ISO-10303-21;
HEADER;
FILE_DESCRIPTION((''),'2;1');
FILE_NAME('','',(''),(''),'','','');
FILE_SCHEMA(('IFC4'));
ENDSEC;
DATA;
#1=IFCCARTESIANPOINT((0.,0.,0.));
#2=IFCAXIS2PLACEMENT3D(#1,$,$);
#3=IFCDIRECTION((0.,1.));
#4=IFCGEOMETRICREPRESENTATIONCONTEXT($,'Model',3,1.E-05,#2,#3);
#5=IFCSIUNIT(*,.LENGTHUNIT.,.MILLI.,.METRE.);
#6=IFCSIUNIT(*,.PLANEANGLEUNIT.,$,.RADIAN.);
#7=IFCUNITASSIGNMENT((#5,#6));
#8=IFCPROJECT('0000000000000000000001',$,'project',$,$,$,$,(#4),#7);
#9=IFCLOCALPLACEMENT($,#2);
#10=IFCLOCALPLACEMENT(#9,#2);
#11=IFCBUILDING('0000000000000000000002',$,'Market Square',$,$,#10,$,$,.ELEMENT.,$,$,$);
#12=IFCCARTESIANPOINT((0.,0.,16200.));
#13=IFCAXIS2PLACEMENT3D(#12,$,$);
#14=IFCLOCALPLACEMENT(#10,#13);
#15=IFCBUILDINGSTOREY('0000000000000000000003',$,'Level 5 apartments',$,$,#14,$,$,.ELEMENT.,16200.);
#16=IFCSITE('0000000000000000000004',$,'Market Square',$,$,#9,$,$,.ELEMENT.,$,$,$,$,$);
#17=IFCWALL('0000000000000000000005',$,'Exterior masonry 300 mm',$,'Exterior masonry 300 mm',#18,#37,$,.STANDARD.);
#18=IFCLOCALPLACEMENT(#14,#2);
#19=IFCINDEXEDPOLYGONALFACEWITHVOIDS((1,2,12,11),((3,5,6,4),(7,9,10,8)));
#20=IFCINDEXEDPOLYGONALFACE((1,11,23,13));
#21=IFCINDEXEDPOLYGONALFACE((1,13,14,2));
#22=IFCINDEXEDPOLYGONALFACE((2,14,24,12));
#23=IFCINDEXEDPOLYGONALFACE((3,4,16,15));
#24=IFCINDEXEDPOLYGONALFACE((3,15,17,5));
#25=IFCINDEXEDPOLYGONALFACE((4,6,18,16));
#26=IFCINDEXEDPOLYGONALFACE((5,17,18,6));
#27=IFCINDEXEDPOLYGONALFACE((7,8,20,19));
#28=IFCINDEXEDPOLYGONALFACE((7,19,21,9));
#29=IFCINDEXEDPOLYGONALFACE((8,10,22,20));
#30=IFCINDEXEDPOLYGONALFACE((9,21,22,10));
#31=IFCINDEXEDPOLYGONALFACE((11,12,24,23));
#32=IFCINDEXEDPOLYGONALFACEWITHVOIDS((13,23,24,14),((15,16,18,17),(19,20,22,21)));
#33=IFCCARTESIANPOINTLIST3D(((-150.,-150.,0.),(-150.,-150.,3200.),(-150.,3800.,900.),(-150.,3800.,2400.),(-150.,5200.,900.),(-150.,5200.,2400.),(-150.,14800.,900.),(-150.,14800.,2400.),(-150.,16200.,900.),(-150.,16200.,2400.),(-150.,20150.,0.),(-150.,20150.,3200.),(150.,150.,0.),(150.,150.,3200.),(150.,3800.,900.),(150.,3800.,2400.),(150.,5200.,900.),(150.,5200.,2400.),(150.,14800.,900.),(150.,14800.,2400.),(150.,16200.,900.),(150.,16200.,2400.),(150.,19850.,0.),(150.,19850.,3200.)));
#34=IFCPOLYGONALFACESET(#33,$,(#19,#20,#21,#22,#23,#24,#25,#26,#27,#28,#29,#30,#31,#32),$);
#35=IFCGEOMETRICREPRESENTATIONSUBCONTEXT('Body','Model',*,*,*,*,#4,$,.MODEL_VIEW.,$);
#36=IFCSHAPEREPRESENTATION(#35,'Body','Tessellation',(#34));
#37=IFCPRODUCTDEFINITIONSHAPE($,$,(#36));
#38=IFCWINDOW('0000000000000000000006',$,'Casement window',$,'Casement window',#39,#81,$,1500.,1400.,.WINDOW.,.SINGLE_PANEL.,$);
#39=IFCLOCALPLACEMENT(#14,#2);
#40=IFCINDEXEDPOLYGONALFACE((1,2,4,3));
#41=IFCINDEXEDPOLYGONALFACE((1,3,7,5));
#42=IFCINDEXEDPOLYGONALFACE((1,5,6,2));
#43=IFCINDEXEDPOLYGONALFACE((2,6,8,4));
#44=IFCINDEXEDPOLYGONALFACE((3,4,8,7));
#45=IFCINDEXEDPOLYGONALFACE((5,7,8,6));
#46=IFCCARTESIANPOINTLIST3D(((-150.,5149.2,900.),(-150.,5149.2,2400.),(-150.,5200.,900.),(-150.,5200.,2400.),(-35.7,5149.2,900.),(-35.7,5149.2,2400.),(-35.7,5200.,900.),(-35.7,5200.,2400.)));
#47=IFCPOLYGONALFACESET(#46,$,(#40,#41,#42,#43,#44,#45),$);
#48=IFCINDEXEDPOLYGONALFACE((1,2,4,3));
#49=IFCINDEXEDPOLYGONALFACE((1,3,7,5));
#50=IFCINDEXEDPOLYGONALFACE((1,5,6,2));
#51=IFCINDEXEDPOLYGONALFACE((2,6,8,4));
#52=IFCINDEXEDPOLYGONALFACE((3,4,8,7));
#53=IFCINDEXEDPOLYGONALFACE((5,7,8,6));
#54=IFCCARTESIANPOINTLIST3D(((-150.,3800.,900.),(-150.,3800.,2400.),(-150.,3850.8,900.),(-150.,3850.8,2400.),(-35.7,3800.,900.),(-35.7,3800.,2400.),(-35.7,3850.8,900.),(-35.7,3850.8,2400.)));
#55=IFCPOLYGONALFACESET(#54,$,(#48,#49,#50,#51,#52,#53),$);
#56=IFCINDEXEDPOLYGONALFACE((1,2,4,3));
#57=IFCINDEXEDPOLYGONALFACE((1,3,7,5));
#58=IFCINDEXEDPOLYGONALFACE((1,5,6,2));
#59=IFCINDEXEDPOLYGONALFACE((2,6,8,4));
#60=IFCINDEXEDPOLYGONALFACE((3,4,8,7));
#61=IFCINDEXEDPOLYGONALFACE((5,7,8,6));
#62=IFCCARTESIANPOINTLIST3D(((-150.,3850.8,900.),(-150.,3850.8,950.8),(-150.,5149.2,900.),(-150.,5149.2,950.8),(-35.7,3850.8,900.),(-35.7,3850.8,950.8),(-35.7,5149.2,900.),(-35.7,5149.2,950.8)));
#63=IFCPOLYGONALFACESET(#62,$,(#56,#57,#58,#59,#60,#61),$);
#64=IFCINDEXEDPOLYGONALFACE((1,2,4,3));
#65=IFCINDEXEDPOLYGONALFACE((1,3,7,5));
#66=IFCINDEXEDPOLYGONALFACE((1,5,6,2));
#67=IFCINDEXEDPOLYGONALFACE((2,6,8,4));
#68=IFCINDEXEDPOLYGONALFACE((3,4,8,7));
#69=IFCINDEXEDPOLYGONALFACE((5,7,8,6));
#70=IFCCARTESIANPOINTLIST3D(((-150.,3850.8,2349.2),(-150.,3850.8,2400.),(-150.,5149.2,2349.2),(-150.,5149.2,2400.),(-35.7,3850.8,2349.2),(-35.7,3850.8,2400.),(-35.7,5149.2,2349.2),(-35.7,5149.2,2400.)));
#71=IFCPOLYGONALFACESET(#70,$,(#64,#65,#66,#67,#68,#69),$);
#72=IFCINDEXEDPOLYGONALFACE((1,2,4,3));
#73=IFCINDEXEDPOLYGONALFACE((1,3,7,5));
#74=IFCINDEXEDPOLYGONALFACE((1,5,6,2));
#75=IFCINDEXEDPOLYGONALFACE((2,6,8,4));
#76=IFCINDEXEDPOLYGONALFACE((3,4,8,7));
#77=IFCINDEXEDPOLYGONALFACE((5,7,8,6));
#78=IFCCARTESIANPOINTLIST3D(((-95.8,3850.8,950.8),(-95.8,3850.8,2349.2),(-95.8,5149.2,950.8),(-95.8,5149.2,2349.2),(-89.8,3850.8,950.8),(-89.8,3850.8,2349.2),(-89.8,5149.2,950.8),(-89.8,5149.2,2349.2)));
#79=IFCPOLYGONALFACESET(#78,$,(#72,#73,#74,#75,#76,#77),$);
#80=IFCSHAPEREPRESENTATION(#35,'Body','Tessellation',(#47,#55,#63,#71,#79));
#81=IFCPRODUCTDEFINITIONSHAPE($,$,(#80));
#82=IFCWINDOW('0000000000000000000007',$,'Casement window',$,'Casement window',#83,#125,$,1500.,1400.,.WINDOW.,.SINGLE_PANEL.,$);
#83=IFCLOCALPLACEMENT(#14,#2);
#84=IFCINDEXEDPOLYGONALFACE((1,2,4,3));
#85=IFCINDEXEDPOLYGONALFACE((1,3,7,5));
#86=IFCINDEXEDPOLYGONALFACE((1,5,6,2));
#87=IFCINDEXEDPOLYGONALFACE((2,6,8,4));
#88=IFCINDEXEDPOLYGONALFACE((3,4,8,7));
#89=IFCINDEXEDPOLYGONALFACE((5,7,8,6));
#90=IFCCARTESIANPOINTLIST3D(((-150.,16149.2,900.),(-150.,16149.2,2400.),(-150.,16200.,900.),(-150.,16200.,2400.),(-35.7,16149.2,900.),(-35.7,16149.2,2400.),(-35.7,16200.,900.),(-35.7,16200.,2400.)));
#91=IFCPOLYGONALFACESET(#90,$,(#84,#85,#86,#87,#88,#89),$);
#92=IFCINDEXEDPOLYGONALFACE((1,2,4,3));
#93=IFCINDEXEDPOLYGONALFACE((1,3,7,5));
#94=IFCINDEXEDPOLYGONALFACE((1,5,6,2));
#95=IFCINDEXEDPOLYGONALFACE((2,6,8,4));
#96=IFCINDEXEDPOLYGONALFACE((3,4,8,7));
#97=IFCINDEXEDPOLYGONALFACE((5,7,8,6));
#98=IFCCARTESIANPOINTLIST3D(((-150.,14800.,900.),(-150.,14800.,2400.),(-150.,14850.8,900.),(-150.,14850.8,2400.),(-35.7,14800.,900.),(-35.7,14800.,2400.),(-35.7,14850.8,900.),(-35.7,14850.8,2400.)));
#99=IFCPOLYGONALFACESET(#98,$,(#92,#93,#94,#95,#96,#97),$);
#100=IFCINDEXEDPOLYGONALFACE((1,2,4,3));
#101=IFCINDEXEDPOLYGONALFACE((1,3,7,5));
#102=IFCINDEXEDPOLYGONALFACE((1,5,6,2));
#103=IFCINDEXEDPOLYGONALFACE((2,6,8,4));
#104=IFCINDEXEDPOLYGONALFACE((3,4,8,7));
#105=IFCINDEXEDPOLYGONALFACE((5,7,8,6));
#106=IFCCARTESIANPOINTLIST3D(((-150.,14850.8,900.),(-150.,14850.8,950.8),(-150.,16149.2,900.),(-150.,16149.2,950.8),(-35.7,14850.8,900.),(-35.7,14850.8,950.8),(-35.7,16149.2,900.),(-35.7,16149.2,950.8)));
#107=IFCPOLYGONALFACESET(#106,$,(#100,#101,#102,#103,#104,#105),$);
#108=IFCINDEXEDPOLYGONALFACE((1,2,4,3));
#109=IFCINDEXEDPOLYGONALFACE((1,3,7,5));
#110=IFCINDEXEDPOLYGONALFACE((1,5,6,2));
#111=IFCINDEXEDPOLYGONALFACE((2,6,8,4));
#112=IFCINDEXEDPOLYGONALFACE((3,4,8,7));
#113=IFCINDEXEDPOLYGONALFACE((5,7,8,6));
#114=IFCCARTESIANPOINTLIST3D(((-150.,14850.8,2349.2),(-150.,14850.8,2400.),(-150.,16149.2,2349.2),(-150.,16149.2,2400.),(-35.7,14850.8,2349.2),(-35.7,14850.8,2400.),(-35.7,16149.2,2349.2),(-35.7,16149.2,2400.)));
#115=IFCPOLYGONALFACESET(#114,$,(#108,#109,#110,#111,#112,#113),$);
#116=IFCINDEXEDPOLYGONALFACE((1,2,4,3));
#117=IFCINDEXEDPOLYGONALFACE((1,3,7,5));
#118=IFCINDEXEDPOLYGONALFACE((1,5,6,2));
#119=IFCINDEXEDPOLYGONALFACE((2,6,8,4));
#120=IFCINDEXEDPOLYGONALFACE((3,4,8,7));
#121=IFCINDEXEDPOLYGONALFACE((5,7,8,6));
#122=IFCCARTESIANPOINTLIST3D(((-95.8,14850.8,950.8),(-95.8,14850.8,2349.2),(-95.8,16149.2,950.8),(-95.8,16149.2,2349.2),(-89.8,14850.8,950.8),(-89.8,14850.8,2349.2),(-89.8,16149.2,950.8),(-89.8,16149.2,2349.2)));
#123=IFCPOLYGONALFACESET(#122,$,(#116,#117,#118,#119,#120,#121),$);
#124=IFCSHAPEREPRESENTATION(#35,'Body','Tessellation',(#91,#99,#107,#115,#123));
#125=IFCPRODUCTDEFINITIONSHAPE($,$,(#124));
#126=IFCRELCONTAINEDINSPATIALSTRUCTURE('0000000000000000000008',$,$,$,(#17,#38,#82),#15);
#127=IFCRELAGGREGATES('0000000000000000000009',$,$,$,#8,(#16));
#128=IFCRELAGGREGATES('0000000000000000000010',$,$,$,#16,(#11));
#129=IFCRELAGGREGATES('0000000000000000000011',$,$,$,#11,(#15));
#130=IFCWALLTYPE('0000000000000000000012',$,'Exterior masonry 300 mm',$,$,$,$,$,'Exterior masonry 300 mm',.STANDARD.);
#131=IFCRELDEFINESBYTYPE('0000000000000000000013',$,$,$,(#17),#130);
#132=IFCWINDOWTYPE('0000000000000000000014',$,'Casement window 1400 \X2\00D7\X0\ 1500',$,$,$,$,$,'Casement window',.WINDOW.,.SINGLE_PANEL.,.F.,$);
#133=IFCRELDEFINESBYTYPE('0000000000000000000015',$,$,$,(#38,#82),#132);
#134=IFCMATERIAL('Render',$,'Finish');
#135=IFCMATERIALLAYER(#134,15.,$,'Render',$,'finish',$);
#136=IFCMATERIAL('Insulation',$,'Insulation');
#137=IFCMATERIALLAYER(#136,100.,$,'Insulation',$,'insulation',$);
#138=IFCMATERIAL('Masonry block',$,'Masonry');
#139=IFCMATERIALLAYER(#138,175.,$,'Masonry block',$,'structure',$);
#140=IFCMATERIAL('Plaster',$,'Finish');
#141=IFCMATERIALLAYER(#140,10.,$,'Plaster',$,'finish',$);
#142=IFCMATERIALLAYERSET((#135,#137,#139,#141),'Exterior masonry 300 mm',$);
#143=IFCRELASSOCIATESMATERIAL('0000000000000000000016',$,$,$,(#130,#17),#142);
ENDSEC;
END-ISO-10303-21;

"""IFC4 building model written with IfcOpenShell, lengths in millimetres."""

from ifc_helpers import new_model, si_unit, direction, frame, origin, origin_with_axes, place, context, subcontext, project, spatial, polyline, outline, extrude, material, layer, layer_set, layer_usage, type_object, element, fill, save


model = new_model("IFC4")

# Units and contexts
model_context = context("Model", 3, precision=1e-05, world=origin(), true_north=direction((0.0, 1.0)))
body_context = subcontext(model_context, "Body", "Model", "MODEL_VIEW")
ifc_project = project(units=[si_unit("LENGTHUNIT", "METRE", prefix="MILLI"), si_unit("PLANEANGLEUNIT", "RADIAN")], contexts=[model_context])

# Site, building, storey
site_placement = place(None, origin())
site = spatial("IfcSite", under=ifc_project, at=site_placement, Name="Market Square", CompositionType="ELEMENT")
building_placement = place(site_placement, origin())
building = spatial("IfcBuilding", under=site, at=building_placement, Name="Market Square", CompositionType="ELEMENT")
storey_placement = place(building_placement, frame((0.0, 0.0, 16200.0)))
storey = spatial("IfcBuildingStorey", under=building, at=storey_placement, Name="Level 5 apartments", CompositionType="ELEMENT", Elevation=16200.0)

# Wall, openings, windows
ifc_material_1 = material(Name="Render", Category="Finish")
ifc_layer_1 = layer(ifc_material_1, 15.0, Name="Render", Category="finish")
ifc_material_2 = material(Name="Insulation", Category="Insulation")
ifc_layer_2 = layer(ifc_material_2, 100.0, Name="Insulation", Category="insulation")
ifc_material_3 = material(Name="Masonry block", Category="Masonry")
ifc_layer_3 = layer(ifc_material_3, 175.0, Name="Masonry block", Category="structure")
ifc_material_4 = material(Name="Plaster", Category="Finish")
ifc_layer_4 = layer(ifc_material_4, 10.0, Name="Plaster", Category="finish")
ifc_layer_set_1 = layer_set([ifc_layer_1, ifc_layer_2, ifc_layer_3, ifc_layer_4], Name="Exterior masonry 300 mm")
ifc_layer_usage_1 = layer_usage(ifc_layer_set_1, "AXIS2", "POSITIVE", -150.0)
wall_type_1 = type_object("IfcWallType", Name="Exterior masonry 300 mm", ElementType="Exterior masonry 300 mm", PredefinedType="STANDARD", material=ifc_layer_set_1)
wall_1_placement = place(storey_placement, frame((0.0, 20000.0, 0.0), z_axis=(0.0, 0.0, 1.0), x_axis=(0.0, -1.0, 0.0)))
wall_1 = element("IfcWall", 1, at=wall_1_placement, inside=storey, type_object=wall_type_1, material=ifc_layer_usage_1, Name="Exterior masonry 300 mm", ObjectType="Exterior masonry 300 mm", PredefinedType="STANDARD", context=body_context, shape_type="SweptSolid", body=[
    extrude(outline(polyline([(-150.0, -150.0), (20150.0, -150.0), (19850.0, 150.0), (150.0, 150.0), (-150.0, -150.0)])), origin(), (0.0, 0.0, 1.0), 3200.0),
])
opening_1_placement = place(wall_1_placement, frame((14800.0, 0.0, 900.0), z_axis=(0.0, 0.0, 1.0), x_axis=(1.0, 0.0, 0.0)))
opening_1 = element("IfcOpeningElement", 2, at=opening_1_placement, cuts=wall_1, PredefinedType="OPENING", context=body_context, shape_type="SweptSolid", body=[
    extrude(outline(polyline([(0.0, -160.0), (1400.0, -160.0), (1400.0, 160.0), (0.0, 160.0), (0.0, -160.0)])), origin(), (0.0, 0.0, 1.0), 1500.0),
])
opening_2_placement = place(wall_1_placement, frame((3800.0, 0.0, 900.0), z_axis=(0.0, 0.0, 1.0), x_axis=(1.0, 0.0, 0.0)))
opening_2 = element("IfcOpeningElement", 3, at=opening_2_placement, cuts=wall_1, PredefinedType="OPENING", context=body_context, shape_type="SweptSolid", body=[
    extrude(outline(polyline([(0.0, -160.0), (1400.0, -160.0), (1400.0, 160.0), (0.0, 160.0), (0.0, -160.0)])), origin(), (0.0, 0.0, 1.0), 1500.0),
])
window_type = type_object("IfcWindowType", Name="Casement window 1400 × 1500", ElementType="Casement window", ParameterTakesPrecedence=False, PartitioningType="SINGLE_PANEL", PredefinedType="WINDOW")
window_1_placement = place(opening_1_placement, origin_with_axes())
window_1 = element("IfcWindow", 4, at=window_1_placement, inside=storey, type_object=window_type, Name="Casement window", ObjectType="Casement window", OverallHeight=1500.0, OverallWidth=1400.0, PartitioningType="SINGLE_PANEL", PredefinedType="WINDOW", context=body_context, shape_type="SweptSolid", body=[
    extrude(outline(polyline([(0.0, -150.0), (50.8, -150.0), (50.8, -35.7), (0.0, -35.7), (0.0, -150.0)])), origin(), (0.0, 0.0, 1.0), 1500.0),
    extrude(outline(polyline([(1349.2, -150.0), (1400.0, -150.0), (1400.0, -35.7), (1349.2, -35.7), (1349.2, -150.0)])), origin(), (0.0, 0.0, 1.0), 1500.0),
    extrude(outline(polyline([(50.8, -150.0), (1349.2, -150.0), (1349.2, -35.7), (50.8, -35.7), (50.8, -150.0)])), origin(), (0.0, 0.0, 1.0), 50.8),
    extrude(outline(polyline([(50.8, -150.0), (1349.2, -150.0), (1349.2, -35.7), (50.8, -35.7), (50.8, -150.0)])), frame((0.0, 0.0, 1449.2)), (0.0, 0.0, 1.0), 50.8),
    extrude(outline(polyline([(50.8, -95.8), (1349.2, -95.8), (1349.2, -89.8), (50.8, -89.8), (50.8, -95.8)])), frame((0.0, 0.0, 50.8)), (0.0, 0.0, 1.0), 1398.4),
])
fill(opening_1, window_1)
window_2_placement = place(opening_2_placement, origin_with_axes())
window_2 = element("IfcWindow", 5, at=window_2_placement, inside=storey, type_object=window_type, Name="Casement window", ObjectType="Casement window", OverallHeight=1500.0, OverallWidth=1400.0, PartitioningType="SINGLE_PANEL", PredefinedType="WINDOW", context=body_context, shape_type="SweptSolid", body=[
    extrude(outline(polyline([(0.0, -150.0), (50.8, -150.0), (50.8, -35.7), (0.0, -35.7), (0.0, -150.0)])), origin(), (0.0, 0.0, 1.0), 1500.0),
    extrude(outline(polyline([(1349.2, -150.0), (1400.0, -150.0), (1400.0, -35.7), (1349.2, -35.7), (1349.2, -150.0)])), origin(), (0.0, 0.0, 1.0), 1500.0),
    extrude(outline(polyline([(50.8, -150.0), (1349.2, -150.0), (1349.2, -35.7), (50.8, -35.7), (50.8, -150.0)])), origin(), (0.0, 0.0, 1.0), 50.8),
    extrude(outline(polyline([(50.8, -150.0), (1349.2, -150.0), (1349.2, -35.7), (50.8, -35.7), (50.8, -150.0)])), frame((0.0, 0.0, 1449.2)), (0.0, 0.0, 1.0), 50.8),
    extrude(outline(polyline([(50.8, -95.8), (1349.2, -95.8), (1349.2, -89.8), (50.8, -89.8), (50.8, -95.8)])), frame((0.0, 0.0, 50.8)), (0.0, 0.0, 1.0), 1398.4),
])
fill(opening_2, window_2)

save(model, "model.ifc")
